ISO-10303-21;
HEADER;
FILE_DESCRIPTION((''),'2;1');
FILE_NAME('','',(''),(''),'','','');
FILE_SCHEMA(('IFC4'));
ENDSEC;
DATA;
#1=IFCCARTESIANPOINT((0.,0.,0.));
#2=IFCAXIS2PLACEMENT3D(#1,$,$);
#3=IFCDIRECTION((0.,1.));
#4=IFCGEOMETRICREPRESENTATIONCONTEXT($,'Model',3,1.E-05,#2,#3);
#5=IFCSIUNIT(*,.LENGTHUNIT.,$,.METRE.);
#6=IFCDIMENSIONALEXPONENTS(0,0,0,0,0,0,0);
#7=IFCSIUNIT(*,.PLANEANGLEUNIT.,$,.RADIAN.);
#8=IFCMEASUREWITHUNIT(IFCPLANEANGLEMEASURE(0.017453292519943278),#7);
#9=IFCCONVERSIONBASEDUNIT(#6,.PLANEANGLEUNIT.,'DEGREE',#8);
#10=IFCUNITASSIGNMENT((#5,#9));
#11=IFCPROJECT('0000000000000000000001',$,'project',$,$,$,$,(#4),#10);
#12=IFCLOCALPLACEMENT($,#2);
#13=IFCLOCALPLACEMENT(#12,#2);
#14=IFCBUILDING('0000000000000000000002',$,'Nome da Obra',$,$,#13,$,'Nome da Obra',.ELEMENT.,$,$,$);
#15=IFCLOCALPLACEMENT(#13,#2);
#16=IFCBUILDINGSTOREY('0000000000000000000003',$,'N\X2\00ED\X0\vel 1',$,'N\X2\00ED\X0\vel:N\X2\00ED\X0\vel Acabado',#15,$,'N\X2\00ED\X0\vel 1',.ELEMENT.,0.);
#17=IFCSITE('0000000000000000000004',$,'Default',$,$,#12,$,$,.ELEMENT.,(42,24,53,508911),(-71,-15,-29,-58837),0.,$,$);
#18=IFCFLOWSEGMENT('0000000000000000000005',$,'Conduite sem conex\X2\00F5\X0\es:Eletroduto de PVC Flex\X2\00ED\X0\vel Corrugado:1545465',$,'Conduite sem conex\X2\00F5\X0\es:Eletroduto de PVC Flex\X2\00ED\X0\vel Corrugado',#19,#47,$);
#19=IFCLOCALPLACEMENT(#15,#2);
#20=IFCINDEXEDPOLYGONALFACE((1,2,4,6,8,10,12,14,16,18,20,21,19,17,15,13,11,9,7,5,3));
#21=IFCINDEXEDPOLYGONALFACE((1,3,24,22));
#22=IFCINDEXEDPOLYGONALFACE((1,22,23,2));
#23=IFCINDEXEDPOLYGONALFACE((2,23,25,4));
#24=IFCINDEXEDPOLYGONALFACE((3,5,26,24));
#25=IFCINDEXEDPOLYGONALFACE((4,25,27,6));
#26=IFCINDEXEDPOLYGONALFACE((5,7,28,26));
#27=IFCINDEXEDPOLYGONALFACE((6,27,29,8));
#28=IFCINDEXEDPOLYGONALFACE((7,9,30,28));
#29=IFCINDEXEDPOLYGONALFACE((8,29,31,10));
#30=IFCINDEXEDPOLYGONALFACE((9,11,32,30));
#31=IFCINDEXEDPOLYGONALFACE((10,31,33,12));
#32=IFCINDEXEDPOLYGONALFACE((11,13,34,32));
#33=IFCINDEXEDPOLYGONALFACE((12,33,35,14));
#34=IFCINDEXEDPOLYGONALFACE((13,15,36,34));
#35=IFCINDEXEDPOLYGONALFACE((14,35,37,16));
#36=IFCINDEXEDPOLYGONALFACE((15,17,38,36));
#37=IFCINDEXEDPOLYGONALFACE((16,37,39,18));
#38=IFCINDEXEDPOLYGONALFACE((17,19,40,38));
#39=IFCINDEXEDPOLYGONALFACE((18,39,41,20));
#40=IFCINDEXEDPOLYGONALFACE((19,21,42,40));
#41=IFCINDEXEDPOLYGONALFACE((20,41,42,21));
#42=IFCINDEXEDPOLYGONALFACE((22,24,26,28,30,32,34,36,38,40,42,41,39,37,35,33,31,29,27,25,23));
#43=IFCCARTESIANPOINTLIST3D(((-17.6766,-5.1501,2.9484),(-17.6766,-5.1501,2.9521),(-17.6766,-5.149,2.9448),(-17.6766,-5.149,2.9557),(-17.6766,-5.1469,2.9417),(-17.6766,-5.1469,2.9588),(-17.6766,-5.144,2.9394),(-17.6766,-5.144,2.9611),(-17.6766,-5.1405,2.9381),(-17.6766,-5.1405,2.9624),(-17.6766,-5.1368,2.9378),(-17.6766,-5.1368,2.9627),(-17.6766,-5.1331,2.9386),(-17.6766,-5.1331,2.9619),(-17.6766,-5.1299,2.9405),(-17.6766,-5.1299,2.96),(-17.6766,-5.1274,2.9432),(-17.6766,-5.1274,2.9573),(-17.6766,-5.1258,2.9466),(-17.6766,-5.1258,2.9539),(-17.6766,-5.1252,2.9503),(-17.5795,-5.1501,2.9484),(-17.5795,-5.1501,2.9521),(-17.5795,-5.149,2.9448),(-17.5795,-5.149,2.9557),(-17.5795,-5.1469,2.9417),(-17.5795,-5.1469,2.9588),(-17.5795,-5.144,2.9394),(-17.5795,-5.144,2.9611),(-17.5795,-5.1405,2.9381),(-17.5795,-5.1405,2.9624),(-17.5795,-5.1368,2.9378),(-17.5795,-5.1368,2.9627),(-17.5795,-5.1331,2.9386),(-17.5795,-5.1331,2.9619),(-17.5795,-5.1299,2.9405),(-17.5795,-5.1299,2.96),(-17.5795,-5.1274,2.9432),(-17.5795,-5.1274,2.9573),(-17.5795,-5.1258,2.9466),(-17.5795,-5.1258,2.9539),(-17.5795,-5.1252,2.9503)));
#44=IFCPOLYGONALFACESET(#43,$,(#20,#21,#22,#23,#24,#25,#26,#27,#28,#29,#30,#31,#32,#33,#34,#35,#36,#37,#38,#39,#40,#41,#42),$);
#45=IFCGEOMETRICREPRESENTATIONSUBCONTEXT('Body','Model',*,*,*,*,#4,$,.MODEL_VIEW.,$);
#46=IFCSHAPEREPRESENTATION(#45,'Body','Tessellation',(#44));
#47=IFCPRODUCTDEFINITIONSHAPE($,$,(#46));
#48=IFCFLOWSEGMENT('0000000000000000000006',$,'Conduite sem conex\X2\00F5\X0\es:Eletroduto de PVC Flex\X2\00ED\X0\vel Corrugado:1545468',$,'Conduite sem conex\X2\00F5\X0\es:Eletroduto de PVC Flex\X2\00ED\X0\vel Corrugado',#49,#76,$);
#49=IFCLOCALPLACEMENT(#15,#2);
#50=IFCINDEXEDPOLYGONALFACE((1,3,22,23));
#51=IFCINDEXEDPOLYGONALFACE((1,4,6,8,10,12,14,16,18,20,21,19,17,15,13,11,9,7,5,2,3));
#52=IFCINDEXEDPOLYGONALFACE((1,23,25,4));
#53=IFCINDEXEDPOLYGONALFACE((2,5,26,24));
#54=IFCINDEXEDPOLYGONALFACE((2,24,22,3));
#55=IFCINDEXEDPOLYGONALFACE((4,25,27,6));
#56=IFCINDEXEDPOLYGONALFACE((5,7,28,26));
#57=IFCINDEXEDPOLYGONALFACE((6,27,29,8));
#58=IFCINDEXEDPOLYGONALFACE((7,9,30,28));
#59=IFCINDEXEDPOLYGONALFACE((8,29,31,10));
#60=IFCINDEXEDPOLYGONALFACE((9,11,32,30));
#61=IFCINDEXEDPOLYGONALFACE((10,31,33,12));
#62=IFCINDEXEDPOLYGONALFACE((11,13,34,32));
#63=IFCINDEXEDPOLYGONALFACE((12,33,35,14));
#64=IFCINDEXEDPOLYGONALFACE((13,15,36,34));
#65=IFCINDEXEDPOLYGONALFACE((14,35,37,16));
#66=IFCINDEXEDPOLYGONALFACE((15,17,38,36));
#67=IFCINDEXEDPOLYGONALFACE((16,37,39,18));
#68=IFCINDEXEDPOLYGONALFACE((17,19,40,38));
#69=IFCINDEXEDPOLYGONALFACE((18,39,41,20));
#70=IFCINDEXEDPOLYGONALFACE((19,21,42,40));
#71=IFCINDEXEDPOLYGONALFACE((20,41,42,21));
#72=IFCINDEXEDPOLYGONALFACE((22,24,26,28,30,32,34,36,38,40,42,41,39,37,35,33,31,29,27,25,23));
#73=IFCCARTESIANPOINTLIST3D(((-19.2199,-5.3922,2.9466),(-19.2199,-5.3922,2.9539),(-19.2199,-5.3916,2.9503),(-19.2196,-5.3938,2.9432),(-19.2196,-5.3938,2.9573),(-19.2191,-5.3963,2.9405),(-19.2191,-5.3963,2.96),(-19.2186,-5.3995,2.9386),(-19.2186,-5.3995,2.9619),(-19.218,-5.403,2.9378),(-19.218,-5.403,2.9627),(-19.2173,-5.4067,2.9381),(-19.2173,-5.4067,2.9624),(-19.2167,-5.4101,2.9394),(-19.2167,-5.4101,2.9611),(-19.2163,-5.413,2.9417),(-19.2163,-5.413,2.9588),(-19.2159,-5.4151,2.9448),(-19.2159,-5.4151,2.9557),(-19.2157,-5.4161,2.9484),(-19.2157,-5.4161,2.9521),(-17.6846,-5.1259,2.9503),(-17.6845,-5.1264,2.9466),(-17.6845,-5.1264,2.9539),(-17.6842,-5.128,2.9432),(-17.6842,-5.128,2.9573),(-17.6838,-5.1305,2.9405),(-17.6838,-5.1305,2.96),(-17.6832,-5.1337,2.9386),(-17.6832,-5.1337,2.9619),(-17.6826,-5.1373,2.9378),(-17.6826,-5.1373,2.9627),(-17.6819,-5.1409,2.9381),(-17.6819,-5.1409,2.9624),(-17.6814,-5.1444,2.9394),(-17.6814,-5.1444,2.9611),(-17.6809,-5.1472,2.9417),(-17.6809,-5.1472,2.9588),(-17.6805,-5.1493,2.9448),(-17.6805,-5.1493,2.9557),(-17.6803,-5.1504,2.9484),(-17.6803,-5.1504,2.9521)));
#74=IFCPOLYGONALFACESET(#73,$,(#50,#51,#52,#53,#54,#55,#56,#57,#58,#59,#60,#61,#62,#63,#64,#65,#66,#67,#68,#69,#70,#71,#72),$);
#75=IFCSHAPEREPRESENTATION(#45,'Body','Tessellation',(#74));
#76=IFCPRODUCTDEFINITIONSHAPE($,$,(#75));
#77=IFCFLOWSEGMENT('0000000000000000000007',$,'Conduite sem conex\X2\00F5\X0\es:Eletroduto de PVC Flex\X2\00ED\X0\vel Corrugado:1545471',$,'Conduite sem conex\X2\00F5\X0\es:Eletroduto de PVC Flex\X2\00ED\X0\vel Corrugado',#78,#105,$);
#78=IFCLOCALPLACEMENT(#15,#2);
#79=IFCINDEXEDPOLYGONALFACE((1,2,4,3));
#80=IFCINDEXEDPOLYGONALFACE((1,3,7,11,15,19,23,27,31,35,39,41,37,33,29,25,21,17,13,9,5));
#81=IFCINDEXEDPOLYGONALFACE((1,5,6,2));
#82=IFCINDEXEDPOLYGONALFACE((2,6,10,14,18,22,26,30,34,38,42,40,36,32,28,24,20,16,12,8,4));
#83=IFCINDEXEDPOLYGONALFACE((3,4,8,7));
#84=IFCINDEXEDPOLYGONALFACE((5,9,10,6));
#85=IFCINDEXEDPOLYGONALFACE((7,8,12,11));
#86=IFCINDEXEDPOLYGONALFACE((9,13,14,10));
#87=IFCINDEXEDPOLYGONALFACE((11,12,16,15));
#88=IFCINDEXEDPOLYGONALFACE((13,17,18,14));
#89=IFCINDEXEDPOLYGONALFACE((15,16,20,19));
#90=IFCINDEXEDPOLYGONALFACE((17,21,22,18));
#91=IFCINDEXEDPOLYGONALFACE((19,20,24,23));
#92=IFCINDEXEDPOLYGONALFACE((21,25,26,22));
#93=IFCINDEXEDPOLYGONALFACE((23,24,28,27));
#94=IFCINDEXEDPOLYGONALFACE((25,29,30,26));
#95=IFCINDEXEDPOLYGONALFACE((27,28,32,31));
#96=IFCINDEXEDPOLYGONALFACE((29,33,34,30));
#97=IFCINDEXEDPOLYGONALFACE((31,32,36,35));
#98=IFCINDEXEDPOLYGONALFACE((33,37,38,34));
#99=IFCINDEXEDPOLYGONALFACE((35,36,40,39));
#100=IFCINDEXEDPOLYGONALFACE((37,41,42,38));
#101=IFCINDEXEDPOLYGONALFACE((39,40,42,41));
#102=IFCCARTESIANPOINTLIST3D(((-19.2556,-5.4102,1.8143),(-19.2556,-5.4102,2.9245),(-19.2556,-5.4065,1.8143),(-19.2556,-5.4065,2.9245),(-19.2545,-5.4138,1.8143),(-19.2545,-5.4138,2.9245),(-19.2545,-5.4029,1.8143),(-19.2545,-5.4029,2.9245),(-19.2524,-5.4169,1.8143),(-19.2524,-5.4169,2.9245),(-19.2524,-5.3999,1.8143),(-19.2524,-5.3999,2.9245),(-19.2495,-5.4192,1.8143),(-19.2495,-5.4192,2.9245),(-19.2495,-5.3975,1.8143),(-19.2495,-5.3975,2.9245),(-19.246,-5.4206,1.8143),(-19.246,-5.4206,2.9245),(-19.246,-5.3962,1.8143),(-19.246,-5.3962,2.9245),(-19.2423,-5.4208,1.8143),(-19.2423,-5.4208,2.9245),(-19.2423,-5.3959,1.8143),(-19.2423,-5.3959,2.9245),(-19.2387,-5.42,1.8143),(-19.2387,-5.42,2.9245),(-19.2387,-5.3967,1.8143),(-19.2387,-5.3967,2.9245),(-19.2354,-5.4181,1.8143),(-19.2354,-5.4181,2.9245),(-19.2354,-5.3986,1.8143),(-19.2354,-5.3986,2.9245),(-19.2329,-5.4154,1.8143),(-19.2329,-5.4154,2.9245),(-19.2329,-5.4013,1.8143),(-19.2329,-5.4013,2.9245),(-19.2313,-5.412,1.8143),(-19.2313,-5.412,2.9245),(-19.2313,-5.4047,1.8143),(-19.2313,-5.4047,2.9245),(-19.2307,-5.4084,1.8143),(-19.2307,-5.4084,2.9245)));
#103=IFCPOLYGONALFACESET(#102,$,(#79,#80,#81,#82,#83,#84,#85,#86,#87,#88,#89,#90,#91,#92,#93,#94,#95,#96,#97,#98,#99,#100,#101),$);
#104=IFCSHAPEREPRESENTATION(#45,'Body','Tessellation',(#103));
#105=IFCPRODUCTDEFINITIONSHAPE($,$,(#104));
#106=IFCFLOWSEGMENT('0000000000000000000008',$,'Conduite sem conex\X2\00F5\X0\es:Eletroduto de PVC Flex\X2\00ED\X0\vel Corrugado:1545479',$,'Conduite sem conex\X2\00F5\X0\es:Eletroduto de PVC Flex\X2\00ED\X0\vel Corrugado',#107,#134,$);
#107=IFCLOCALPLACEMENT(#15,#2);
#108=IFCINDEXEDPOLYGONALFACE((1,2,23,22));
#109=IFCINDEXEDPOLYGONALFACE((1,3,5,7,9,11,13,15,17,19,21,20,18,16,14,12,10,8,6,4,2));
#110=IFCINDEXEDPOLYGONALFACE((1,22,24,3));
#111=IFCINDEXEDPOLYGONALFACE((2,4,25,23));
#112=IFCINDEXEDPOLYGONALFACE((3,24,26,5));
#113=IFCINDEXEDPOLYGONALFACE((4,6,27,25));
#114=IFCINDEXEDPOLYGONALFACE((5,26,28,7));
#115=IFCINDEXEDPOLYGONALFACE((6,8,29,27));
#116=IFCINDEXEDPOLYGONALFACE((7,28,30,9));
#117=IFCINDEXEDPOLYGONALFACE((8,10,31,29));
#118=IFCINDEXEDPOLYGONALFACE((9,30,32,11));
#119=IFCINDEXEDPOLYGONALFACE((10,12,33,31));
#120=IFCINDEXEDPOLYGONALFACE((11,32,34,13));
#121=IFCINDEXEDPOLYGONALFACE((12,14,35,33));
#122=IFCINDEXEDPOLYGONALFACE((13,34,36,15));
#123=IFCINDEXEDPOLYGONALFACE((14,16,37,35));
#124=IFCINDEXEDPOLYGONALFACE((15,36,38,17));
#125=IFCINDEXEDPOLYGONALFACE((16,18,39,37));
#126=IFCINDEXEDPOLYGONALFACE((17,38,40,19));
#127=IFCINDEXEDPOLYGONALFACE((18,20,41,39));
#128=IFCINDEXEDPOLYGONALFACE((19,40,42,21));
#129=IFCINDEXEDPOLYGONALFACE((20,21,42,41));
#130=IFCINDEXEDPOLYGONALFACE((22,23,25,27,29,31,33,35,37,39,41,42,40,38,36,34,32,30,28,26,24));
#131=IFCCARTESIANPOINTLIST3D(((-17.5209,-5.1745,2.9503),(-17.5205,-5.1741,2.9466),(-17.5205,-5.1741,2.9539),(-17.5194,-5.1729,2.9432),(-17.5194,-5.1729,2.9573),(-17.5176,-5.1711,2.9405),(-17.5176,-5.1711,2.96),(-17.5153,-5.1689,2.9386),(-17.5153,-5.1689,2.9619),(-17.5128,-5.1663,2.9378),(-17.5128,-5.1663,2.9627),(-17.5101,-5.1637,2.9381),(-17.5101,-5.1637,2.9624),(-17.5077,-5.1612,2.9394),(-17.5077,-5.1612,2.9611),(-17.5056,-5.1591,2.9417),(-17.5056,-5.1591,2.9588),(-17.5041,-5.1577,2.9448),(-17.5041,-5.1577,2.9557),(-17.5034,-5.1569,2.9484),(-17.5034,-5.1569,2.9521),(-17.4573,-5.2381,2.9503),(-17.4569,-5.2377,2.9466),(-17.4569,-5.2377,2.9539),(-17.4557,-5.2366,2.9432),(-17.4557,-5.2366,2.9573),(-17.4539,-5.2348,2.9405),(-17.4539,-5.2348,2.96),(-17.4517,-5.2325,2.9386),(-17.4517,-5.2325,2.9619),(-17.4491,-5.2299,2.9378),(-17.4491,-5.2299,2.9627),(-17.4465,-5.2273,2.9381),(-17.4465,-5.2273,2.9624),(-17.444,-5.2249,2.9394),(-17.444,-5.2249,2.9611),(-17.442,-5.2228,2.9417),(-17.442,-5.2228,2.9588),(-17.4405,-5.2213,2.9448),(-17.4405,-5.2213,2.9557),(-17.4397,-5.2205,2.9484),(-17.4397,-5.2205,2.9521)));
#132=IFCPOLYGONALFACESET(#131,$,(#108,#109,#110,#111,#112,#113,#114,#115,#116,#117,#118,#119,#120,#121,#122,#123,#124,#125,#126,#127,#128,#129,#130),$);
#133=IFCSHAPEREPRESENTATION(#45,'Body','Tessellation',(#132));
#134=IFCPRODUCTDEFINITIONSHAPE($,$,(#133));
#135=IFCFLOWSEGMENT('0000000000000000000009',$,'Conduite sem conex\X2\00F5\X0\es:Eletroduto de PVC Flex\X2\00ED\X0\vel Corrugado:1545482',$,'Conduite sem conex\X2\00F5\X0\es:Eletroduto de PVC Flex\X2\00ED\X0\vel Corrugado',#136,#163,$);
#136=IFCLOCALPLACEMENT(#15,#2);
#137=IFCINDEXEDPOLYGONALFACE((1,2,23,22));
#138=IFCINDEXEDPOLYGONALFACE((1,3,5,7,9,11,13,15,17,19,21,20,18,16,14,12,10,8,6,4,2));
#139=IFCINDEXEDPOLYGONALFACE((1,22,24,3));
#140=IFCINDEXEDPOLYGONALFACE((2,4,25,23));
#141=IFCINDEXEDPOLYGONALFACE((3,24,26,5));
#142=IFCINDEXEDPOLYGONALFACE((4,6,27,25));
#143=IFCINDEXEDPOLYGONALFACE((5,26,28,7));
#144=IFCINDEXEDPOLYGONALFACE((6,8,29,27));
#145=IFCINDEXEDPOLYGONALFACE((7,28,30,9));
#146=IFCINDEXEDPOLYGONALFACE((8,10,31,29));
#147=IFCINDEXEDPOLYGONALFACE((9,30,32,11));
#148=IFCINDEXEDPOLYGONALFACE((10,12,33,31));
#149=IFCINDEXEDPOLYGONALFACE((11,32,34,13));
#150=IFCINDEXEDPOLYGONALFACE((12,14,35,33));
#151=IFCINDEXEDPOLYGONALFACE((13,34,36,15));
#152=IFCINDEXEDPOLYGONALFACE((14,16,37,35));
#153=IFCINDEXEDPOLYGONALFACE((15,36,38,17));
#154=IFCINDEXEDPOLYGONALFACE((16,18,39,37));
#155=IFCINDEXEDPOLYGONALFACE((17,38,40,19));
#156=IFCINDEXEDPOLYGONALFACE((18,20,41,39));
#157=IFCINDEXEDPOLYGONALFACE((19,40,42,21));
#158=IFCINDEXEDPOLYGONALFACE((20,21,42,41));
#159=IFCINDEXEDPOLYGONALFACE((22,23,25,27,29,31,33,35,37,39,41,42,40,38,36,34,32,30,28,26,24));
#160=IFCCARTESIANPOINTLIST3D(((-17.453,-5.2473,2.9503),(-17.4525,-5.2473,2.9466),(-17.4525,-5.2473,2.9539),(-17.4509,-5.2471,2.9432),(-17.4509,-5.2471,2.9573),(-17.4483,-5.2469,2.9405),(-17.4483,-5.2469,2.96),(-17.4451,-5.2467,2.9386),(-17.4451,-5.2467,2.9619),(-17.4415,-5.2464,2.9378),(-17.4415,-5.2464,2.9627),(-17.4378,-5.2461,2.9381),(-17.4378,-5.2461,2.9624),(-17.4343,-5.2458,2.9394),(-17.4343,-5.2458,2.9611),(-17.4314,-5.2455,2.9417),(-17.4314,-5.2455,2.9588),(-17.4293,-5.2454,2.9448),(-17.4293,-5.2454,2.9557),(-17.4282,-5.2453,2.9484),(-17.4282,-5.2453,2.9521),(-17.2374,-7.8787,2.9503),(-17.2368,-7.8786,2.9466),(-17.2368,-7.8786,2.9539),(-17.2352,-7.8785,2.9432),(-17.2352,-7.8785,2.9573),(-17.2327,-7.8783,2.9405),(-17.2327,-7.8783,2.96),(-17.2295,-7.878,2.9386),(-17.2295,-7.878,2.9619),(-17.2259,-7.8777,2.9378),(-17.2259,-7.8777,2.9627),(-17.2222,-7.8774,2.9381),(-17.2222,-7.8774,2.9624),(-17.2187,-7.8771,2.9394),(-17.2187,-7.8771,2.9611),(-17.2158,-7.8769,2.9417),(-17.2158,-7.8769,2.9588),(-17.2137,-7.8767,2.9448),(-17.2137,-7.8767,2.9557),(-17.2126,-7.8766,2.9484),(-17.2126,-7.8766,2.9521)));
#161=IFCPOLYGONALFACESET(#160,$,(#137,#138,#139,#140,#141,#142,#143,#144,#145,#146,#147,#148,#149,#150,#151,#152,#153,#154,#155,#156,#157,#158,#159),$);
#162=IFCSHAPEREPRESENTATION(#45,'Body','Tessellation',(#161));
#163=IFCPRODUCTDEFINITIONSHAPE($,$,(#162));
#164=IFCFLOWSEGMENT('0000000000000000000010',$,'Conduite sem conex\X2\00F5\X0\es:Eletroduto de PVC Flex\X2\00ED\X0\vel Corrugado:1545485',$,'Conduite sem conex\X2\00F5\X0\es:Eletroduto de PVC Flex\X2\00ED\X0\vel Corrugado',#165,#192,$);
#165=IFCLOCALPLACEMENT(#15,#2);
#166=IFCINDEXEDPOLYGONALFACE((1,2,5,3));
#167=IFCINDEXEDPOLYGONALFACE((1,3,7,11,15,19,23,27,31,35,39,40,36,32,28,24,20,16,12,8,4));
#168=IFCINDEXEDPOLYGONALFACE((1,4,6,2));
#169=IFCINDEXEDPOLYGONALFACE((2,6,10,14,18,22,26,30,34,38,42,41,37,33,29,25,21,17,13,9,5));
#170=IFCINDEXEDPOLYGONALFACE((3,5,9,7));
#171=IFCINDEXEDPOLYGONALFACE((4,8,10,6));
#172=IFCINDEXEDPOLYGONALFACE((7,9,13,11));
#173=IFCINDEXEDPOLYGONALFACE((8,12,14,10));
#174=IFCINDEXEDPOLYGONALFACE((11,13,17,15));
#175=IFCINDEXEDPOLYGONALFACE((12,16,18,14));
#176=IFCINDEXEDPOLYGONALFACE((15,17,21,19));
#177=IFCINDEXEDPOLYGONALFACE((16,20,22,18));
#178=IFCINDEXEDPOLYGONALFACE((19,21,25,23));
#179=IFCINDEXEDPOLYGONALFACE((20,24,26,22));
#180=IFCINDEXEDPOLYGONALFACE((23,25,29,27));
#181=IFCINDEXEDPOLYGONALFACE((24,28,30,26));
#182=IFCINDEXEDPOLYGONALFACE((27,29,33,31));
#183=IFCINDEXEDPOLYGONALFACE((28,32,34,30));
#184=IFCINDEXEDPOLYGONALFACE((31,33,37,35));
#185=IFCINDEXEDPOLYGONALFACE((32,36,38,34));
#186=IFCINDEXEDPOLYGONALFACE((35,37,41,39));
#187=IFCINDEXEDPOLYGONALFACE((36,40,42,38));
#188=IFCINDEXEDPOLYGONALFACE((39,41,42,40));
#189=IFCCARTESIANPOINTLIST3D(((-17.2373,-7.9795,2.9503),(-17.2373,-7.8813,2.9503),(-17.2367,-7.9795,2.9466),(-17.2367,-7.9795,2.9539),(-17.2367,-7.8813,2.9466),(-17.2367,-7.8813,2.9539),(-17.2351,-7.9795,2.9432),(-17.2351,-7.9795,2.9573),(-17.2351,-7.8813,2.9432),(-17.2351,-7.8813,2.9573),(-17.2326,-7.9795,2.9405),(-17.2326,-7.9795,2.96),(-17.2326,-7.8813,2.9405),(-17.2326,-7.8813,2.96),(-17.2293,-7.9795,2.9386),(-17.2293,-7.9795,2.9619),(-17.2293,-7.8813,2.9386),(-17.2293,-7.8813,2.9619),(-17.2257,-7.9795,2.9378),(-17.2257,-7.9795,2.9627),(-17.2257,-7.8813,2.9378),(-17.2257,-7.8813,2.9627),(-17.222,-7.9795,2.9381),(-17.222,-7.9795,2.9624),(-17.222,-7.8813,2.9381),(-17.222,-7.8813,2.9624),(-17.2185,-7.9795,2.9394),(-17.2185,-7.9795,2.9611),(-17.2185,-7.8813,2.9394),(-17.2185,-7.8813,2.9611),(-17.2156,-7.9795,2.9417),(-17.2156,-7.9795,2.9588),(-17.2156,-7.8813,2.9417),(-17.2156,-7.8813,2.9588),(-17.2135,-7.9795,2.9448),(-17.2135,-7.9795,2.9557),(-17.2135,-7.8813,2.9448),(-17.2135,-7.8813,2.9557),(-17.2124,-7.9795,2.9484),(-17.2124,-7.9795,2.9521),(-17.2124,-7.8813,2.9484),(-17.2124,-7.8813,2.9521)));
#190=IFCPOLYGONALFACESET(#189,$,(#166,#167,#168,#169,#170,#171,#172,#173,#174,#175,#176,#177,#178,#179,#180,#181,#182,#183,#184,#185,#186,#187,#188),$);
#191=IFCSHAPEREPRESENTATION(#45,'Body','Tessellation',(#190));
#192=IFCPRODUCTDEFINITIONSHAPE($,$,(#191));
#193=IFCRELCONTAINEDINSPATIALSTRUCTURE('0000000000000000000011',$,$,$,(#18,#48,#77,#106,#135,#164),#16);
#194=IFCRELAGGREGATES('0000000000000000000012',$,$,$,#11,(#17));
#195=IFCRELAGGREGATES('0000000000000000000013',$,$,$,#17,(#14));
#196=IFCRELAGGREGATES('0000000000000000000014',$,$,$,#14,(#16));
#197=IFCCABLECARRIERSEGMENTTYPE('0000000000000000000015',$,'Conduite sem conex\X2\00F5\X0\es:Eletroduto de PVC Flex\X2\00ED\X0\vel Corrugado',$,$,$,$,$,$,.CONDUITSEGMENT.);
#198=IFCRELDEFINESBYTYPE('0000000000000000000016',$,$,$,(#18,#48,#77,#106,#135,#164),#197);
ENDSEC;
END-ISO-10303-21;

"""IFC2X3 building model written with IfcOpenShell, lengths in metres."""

from ifc_helpers import new_model, entity, si_unit, converted_unit, direction, frame, frame_2d, origin, origin_2d_with_axis, place, context, subcontext, project, spatial, circle, extrude, type_object, element, save


model = new_model("IFC2X3")

# Units and contexts
model_context = context("Model", 3, precision=1e-05, world=origin(), true_north=direction((0.0, 1.0)))
body_context = subcontext(model_context, "Body", "Model", "MODEL_VIEW")
ifc_project = project(units=[si_unit("LENGTHUNIT", "METRE"), converted_unit("PLANEANGLEUNIT", "DEGREE", entity("IfcPlaneAngleMeasure", 0.017453292519943278), si_unit("PLANEANGLEUNIT", "RADIAN"), dimensions=[0, 0, 0, 0, 0, 0, 0])], contexts=[model_context])

# Site, building, storey
site_placement = place(None, origin())
site = spatial("IfcSite", under=ifc_project, at=site_placement, Name="Default", CompositionType="ELEMENT", RefLatitude=(42, 24, 53, 508911), RefLongitude=(-71, -15, -29, -58837), RefElevation=0.0)
building_placement = place(site_placement, origin())
building = spatial("IfcBuilding", under=site, at=building_placement, Name="Nome da Obra", LongName="Nome da Obra", CompositionType="ELEMENT")
storey_placement = place(building_placement, origin())
storey = spatial("IfcBuildingStorey", under=building, at=storey_placement, Name="Nível 1", ObjectType="Nível:Nível Acabado", LongName="Nível 1", CompositionType="ELEMENT", Elevation=0.0)

# Flow segments
cable_carrier_segment_type = type_object("IfcCableCarrierSegmentType", Name="Conduite sem conexões:Eletroduto de PVC Flexível Corrugado", PredefinedType="CONDUITSEGMENT")
flow_segment_1_placement = place(storey_placement, origin())
element("IfcFlowSegment", 1, at=flow_segment_1_placement, inside=storey, type_object=cable_carrier_segment_type, Name="Conduite sem conexões:Eletroduto de PVC Flexível Corrugado:1545465", ObjectType="Conduite sem conexões:Eletroduto de PVC Flexível Corrugado", context=body_context, shape_type="SweptSolid", body=[
    extrude(circle(Radius=0.0125, at=origin_2d_with_axis()), frame((-17.6766, -5.1377, 2.9503), z_axis=(1.0, 0.0, 0.0), x_axis=(0.0, 1.0, 0.0)), (0.0, 0.0, 1.0), 0.0971),
])
flow_segment_2_placement = place(storey_placement, origin())
element("IfcFlowSegment", 2, at=flow_segment_2_placement, inside=storey, type_object=cable_carrier_segment_type, Name="Conduite sem conexões:Eletroduto de PVC Flexível Corrugado:1545468", ObjectType="Conduite sem conexões:Eletroduto de PVC Flexível Corrugado", context=body_context, shape_type="SweptSolid", body=[
    extrude(circle(Radius=0.0125, at=frame_2d((0.0, 0.0), x_axis=(1.0, 0.0))), frame((-19.2178, -5.404, 2.9503), z_axis=(0.985348, 0.170554, 0.0), x_axis=(-0.170554, 0.985348, 0.0)), (0.0, 0.0, 1.0), 1.5582),
])
flow_segment_3_placement = place(storey_placement, origin())
element("IfcFlowSegment", 3, at=flow_segment_3_placement, inside=storey, type_object=cable_carrier_segment_type, Name="Conduite sem conexões:Eletroduto de PVC Flexível Corrugado:1545471", ObjectType="Conduite sem conexões:Eletroduto de PVC Flexível Corrugado", context=body_context, shape_type="SweptSolid", body=[
    extrude(circle(Radius=0.0125, at=frame_2d((0.0, 0.0), x_axis=(1.0, 0.0))), frame((-19.2432, -5.4084, 1.8143)), (0.0, 0.0, 1.0), 1.1102),
])
flow_segment_4_placement = place(storey_placement, origin())
element("IfcFlowSegment", 4, at=flow_segment_4_placement, inside=storey, type_object=cable_carrier_segment_type, Name="Conduite sem conexões:Eletroduto de PVC Flexível Corrugado:1545479", ObjectType="Conduite sem conexões:Eletroduto de PVC Flexível Corrugado", context=body_context, shape_type="SweptSolid", body=[
    extrude(circle(Radius=0.0125, at=frame_2d((0.0, 0.0), x_axis=(1.0, 0.0))), frame((-17.4484, -5.2293, 2.9503), z_axis=(-0.707107, 0.707107, 0.0), x_axis=(-0.707107, -0.707107, 0.0)), (0.0, 0.0, 1.0), 0.09),
])
flow_segment_5_placement = place(storey_placement, origin())
element("IfcFlowSegment", 5, at=flow_segment_5_placement, inside=storey, type_object=cable_carrier_segment_type, Name="Conduite sem conexões:Eletroduto de PVC Flexível Corrugado:1545482", ObjectType="Conduite sem conexões:Eletroduto de PVC Flexível Corrugado", context=body_context, shape_type="SweptSolid", body=[
    extrude(circle(Radius=0.0125, at=frame_2d((0.0, 0.0), x_axis=(1.0, 0.0))), frame((-17.2249, -7.8777, 2.9503), z_axis=(-0.081677, 0.996659, 0.0), x_axis=(-0.996659, -0.081677, 0.0)), (0.0, 0.0, 1.0), 2.6402),
])
flow_segment_6_placement = place(storey_placement, origin())
element("IfcFlowSegment", 6, at=flow_segment_6_placement, inside=storey, type_object=cable_carrier_segment_type, Name="Conduite sem conexões:Eletroduto de PVC Flexível Corrugado:1545485", ObjectType="Conduite sem conexões:Eletroduto de PVC Flexível Corrugado", context=body_context, shape_type="SweptSolid", body=[
    extrude(circle(Radius=0.0125, at=origin_2d_with_axis()), frame((-17.2248, -7.9795, 2.9503), z_axis=(0.0, 1.0, 0.0), x_axis=(-1.0, 0.0, 0.0)), (0.0, 0.0, 1.0), 0.0982),
])

save(model, "model.ifc")
